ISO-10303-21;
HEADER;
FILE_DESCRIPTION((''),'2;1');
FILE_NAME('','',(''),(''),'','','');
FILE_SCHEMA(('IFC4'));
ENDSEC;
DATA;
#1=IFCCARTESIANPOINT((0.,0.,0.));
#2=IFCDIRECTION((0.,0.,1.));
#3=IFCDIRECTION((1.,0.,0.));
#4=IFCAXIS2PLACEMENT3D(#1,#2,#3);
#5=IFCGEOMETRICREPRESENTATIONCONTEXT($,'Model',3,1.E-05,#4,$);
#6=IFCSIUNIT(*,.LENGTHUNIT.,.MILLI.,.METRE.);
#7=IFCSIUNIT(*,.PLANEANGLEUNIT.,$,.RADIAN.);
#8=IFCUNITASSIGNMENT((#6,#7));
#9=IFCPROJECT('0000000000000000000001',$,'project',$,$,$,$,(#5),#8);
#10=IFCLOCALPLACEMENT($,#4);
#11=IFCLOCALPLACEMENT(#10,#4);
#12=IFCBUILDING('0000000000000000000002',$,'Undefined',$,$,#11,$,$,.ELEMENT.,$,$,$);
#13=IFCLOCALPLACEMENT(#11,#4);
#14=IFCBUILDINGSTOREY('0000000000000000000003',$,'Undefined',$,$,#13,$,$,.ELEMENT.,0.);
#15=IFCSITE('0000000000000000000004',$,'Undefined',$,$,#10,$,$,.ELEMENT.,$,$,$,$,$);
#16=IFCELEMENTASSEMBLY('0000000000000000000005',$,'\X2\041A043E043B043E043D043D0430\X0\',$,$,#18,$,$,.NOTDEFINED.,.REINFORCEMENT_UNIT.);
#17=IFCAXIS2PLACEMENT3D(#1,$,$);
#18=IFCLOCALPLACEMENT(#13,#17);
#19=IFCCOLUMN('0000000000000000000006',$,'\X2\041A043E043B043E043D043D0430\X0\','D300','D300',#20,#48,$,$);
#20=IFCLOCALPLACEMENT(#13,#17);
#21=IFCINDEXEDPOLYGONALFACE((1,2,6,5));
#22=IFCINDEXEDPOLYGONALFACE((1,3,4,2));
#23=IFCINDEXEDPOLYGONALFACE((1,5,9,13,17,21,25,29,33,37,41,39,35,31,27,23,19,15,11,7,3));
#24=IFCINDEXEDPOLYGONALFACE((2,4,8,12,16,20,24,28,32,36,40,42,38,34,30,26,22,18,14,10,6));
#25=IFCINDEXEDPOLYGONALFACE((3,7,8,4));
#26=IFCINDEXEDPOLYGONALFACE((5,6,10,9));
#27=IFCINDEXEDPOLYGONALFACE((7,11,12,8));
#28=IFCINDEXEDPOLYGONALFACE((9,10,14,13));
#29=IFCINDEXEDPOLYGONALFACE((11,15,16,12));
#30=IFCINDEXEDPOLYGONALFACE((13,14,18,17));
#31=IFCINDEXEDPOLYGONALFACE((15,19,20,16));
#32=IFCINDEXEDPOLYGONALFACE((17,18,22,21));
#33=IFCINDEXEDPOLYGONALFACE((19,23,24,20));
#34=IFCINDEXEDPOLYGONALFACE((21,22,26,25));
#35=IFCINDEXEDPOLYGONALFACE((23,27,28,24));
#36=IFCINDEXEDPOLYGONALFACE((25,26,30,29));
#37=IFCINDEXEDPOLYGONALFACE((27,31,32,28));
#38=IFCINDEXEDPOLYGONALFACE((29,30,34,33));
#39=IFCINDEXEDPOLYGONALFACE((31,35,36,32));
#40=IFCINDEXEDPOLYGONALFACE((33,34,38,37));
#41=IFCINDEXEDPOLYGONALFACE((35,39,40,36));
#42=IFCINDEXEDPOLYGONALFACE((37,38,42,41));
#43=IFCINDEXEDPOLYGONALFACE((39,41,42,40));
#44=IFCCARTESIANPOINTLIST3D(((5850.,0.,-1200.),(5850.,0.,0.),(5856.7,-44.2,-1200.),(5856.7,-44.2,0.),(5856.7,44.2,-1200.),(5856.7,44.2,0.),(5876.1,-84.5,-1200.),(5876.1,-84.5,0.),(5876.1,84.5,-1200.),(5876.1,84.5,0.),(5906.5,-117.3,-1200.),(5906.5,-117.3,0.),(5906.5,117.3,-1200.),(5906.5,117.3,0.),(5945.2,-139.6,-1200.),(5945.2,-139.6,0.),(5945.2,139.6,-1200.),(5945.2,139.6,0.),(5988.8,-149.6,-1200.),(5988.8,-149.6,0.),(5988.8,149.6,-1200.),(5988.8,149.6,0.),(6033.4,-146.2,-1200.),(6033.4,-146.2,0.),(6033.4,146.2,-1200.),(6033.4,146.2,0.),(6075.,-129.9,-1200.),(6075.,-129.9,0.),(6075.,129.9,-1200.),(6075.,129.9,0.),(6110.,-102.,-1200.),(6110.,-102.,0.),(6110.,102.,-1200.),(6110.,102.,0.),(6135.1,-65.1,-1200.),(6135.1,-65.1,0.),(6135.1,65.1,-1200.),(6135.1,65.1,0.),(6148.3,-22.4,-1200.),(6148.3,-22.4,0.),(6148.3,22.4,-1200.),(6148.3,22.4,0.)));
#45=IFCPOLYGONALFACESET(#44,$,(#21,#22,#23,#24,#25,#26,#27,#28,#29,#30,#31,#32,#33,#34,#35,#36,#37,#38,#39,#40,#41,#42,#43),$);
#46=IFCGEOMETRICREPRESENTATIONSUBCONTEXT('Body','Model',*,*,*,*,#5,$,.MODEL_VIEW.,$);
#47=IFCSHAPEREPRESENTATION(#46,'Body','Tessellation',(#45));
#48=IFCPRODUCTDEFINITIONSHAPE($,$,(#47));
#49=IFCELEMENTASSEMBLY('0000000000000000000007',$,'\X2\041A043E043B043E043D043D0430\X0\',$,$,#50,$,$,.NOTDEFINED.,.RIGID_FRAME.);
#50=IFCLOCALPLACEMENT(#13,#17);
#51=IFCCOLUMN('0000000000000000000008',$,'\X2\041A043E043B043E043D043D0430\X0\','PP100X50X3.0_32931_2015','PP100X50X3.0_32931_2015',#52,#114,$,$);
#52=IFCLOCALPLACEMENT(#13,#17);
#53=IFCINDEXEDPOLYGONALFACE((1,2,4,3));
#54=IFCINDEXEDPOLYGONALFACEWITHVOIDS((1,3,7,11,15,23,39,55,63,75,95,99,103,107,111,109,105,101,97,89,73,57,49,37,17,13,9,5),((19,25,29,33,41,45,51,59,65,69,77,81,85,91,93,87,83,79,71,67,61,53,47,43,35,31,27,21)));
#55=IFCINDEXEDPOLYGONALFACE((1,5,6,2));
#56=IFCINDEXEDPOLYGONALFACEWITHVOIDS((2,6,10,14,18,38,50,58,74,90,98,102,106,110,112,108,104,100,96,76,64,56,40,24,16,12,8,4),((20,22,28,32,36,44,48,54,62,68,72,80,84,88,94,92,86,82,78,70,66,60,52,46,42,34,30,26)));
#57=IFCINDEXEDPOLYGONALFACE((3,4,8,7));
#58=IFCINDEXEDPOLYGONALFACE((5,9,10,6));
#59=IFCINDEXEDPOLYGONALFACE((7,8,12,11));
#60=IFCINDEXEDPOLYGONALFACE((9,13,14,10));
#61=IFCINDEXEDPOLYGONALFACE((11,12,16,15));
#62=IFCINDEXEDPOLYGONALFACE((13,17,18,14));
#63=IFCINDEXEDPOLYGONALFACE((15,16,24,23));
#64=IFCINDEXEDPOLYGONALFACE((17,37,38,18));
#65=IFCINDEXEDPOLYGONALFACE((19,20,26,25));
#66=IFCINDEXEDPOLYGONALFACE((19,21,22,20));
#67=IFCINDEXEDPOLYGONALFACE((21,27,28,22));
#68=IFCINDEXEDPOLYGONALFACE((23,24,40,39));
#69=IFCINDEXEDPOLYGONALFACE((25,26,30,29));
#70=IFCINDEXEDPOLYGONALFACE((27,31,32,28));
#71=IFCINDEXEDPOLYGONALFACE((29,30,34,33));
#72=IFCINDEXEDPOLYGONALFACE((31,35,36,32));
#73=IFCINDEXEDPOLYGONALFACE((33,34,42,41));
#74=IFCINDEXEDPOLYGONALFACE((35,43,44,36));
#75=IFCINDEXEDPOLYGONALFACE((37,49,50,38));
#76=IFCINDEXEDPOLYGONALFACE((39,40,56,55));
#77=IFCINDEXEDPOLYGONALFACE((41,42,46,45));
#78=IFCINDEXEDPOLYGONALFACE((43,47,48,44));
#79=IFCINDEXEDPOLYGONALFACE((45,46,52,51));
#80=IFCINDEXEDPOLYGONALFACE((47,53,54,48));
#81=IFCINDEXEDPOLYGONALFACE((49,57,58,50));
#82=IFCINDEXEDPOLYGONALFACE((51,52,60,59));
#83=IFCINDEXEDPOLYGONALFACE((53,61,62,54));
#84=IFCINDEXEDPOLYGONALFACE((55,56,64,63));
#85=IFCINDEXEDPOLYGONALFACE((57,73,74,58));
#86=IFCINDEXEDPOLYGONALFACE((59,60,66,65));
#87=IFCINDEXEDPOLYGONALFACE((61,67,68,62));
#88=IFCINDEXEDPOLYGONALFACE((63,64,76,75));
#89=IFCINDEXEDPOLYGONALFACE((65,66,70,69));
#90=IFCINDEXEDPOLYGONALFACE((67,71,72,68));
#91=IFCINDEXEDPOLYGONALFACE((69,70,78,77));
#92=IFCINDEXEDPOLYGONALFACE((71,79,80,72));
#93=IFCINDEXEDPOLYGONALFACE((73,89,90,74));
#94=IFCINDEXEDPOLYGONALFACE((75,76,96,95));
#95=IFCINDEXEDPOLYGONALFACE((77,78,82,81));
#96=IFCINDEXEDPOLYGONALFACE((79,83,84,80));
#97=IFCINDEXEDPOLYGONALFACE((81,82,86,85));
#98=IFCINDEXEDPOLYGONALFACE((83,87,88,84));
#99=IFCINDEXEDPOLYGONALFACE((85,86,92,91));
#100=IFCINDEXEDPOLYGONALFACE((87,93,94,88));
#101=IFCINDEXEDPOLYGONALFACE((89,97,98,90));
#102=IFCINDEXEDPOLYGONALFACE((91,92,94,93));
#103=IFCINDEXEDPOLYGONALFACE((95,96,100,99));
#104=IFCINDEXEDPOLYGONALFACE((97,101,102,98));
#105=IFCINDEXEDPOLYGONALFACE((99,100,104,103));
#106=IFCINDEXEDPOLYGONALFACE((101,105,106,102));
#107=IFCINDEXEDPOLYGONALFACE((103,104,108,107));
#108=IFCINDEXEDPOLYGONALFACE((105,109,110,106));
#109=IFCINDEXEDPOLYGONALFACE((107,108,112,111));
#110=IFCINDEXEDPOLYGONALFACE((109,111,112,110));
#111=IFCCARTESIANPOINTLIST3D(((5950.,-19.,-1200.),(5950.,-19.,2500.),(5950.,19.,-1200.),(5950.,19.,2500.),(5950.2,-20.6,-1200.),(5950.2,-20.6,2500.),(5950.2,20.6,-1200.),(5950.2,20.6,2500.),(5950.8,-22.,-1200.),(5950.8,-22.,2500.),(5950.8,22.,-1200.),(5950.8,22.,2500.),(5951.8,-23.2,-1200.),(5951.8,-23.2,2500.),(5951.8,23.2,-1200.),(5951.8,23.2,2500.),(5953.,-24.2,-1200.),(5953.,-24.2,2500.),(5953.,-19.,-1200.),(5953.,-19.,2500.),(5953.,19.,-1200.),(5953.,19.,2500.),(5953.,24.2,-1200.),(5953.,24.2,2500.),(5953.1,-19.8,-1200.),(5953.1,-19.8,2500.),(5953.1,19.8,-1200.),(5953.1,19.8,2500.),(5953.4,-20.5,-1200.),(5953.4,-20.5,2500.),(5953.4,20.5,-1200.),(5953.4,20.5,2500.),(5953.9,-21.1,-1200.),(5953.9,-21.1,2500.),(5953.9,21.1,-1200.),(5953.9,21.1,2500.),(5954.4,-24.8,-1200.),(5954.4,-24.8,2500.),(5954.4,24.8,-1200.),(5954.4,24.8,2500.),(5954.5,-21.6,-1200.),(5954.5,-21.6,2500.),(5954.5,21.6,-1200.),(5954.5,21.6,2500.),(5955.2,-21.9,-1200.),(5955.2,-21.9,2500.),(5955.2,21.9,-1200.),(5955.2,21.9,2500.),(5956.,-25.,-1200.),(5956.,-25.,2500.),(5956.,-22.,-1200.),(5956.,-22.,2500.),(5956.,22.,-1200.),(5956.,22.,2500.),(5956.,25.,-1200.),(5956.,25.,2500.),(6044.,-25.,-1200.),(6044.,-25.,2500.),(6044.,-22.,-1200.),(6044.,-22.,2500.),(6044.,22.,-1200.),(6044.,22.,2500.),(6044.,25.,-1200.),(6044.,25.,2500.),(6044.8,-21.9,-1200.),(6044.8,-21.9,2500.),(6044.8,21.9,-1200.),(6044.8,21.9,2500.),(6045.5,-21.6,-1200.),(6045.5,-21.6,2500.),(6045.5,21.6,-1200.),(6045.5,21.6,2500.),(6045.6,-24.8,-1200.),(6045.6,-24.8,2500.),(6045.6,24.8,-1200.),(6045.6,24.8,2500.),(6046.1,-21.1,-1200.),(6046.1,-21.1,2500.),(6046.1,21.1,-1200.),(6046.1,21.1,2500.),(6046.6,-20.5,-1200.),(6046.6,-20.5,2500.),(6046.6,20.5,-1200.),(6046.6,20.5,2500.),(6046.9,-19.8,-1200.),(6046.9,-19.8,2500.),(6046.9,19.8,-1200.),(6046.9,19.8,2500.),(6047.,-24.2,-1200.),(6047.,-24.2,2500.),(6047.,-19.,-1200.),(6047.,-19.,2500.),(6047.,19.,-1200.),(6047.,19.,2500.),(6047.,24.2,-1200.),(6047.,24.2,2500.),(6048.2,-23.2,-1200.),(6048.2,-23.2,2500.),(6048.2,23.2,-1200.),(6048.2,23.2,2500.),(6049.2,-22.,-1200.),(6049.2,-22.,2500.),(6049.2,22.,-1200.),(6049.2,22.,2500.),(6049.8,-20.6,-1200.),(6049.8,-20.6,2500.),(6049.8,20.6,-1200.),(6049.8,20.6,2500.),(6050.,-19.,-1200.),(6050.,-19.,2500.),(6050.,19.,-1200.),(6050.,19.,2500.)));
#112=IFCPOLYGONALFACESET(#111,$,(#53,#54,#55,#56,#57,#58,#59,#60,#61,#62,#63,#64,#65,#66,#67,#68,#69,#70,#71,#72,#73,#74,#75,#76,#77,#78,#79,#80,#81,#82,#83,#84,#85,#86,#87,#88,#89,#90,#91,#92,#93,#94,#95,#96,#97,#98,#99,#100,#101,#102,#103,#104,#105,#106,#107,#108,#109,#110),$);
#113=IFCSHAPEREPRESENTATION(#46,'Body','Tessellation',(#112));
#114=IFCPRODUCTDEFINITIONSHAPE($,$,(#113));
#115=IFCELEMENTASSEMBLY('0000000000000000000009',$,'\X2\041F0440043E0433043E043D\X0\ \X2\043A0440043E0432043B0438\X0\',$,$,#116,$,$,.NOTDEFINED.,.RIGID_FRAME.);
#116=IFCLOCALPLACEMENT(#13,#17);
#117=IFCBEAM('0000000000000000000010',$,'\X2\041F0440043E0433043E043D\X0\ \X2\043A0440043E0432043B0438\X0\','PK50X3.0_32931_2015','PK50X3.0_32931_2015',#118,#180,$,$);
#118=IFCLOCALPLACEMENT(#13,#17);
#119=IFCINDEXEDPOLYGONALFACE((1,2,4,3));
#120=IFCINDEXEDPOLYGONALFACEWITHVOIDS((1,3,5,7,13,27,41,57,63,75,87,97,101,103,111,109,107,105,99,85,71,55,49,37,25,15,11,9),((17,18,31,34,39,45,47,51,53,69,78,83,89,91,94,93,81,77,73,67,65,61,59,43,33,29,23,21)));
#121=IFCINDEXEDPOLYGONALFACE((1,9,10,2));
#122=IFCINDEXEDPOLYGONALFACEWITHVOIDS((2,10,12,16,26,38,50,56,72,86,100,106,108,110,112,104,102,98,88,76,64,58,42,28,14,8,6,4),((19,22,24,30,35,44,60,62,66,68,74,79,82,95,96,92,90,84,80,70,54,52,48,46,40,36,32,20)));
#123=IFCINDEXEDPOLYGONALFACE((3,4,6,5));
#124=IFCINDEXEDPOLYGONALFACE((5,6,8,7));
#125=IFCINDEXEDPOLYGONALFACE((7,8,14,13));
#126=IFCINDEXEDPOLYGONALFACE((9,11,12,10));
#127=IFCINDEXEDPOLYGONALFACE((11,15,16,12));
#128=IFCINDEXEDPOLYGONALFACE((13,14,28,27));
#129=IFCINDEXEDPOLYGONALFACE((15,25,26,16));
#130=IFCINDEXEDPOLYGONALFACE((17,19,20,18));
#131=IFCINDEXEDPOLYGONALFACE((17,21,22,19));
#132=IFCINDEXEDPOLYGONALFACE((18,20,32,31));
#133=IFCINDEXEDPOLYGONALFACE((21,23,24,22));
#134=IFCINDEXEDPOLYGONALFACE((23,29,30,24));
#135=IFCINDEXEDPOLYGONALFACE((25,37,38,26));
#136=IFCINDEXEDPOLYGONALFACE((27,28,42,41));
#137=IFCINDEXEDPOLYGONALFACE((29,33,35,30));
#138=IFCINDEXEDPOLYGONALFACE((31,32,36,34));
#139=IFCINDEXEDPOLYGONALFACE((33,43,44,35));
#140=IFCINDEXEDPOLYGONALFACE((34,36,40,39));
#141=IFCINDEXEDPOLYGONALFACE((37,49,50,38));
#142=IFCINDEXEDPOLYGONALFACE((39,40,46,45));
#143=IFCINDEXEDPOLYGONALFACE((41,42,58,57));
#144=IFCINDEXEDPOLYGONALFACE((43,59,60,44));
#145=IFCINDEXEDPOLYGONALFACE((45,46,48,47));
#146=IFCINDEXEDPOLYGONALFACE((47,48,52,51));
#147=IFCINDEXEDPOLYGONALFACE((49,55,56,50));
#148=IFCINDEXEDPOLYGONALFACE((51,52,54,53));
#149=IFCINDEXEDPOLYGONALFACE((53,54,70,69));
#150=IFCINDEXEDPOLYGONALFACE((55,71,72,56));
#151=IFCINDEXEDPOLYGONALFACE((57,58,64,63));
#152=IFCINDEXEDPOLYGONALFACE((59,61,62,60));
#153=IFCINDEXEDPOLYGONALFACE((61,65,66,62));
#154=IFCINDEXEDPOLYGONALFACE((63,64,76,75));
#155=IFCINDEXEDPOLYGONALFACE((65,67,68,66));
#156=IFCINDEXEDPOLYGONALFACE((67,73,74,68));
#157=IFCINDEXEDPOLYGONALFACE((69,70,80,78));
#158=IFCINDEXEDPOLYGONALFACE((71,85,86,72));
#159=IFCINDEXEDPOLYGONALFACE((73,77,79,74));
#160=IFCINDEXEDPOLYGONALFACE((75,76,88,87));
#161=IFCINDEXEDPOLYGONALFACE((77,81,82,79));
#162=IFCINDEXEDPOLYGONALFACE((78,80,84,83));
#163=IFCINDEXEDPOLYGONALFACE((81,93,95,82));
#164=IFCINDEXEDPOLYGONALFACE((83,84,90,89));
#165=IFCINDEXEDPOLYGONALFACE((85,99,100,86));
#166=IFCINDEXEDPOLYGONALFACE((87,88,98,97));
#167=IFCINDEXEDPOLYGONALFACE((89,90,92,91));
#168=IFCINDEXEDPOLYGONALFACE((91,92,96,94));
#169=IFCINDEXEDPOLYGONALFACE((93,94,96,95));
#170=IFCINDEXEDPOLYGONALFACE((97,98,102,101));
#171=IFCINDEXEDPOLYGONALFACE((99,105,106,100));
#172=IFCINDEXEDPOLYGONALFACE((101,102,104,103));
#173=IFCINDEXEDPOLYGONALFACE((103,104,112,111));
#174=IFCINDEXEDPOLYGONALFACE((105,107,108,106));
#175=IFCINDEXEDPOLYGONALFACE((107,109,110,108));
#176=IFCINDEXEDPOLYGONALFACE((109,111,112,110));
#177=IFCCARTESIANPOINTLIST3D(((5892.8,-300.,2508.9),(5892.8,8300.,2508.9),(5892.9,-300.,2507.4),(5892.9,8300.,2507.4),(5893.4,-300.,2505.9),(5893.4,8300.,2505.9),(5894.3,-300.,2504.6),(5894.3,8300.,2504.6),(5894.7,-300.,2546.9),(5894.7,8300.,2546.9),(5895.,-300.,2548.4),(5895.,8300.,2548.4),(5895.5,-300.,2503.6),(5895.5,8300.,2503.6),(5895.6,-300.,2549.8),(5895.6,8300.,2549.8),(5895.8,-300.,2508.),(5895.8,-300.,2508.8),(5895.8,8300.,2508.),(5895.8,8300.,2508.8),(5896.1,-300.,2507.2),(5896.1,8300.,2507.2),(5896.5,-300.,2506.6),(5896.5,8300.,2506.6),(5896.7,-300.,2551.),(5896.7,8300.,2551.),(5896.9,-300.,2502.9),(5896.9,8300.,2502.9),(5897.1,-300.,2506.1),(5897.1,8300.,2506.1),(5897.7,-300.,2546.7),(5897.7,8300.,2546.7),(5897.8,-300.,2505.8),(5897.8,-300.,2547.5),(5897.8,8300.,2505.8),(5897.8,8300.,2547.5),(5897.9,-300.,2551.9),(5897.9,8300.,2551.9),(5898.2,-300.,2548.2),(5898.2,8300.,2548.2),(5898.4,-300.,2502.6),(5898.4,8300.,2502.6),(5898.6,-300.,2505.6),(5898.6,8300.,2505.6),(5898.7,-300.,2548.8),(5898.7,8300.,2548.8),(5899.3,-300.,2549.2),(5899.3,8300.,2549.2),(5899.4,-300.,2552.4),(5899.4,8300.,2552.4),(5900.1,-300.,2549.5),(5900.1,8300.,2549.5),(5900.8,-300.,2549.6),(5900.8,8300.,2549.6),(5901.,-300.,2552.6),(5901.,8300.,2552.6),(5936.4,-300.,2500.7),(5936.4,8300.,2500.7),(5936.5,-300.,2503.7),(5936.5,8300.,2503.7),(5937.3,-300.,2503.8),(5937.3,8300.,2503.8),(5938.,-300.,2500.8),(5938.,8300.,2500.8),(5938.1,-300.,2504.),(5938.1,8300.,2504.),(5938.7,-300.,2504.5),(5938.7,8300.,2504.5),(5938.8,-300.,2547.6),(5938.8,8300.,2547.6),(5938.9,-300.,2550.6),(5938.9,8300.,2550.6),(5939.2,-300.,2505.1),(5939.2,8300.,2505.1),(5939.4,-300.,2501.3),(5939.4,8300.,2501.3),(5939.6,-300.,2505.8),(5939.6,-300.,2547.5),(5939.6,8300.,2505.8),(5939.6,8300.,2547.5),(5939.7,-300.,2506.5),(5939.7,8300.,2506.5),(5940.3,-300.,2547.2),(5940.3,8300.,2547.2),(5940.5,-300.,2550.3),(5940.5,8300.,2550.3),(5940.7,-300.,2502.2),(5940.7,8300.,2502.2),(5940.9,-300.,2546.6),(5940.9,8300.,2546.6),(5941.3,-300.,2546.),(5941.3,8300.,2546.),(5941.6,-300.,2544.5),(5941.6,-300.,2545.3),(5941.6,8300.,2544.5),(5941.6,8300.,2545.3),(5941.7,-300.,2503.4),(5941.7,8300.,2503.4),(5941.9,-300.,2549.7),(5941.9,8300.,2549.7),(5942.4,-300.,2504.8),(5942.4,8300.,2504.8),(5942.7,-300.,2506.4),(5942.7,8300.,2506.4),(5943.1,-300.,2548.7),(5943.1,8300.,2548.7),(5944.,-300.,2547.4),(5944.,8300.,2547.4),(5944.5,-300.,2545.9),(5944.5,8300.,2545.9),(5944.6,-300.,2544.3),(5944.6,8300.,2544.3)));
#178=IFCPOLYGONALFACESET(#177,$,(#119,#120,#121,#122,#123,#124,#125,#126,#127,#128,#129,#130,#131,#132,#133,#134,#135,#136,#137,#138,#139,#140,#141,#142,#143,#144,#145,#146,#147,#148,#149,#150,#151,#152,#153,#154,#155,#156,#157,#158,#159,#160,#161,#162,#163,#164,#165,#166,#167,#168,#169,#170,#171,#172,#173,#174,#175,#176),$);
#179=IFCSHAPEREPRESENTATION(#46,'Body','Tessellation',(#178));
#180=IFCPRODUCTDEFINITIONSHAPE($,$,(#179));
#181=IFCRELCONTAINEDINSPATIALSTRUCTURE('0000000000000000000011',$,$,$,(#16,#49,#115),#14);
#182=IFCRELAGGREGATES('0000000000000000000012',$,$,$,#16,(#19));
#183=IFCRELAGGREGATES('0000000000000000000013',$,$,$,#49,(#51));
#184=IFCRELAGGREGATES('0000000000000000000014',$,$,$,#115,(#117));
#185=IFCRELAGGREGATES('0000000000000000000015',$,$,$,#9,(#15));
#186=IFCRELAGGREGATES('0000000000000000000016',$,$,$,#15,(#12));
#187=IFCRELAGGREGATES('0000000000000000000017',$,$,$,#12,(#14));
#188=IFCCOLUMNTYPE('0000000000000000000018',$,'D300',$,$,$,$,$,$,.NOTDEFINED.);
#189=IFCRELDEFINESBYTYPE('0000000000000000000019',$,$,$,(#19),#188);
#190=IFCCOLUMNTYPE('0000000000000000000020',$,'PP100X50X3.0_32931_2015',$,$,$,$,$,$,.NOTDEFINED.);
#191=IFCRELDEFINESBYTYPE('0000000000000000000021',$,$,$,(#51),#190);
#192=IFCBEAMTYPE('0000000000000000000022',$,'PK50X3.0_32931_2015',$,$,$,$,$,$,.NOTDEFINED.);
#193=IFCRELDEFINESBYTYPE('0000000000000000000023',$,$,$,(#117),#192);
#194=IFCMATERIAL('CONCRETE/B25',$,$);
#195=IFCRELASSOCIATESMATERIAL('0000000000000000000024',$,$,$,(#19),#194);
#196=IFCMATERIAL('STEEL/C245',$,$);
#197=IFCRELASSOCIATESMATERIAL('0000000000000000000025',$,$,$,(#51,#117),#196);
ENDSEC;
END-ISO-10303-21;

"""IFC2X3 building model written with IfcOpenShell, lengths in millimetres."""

from ifc_helpers import new_model, si_unit, frame, origin_with_axes, origin_2d_with_axis, place, context, subcontext, project, spatial, hollow_rectangle, circle, extrude, material, type_object, element, aggregate, save


model = new_model("IFC2X3")

# Units and contexts
model_context = context("Model", 3, precision=1e-05, world=origin_with_axes())
body_context = subcontext(model_context, "Body", "Model", "MODEL_VIEW")
ifc_project = project(units=[si_unit("LENGTHUNIT", "METRE", prefix="MILLI"), si_unit("PLANEANGLEUNIT", "RADIAN")], contexts=[model_context])

# Site, building, storey
site_placement = place(None, origin_with_axes())
site = spatial("IfcSite", under=ifc_project, at=site_placement, Name="Undefined", CompositionType="ELEMENT")
building_placement = place(site_placement, origin_with_axes())
building = spatial("IfcBuilding", under=site, at=building_placement, Name="Undefined", CompositionType="ELEMENT")
storey_placement = place(building_placement, origin_with_axes())
storey = spatial("IfcBuildingStorey", under=building, at=storey_placement, Name="Undefined", CompositionType="ELEMENT", Elevation=0.0)

# Element assemblies, columns
assembly_1_placement = place(storey_placement, origin_with_axes())
assembly_1 = element("IfcElementAssembly", 1, at=assembly_1_placement, inside=storey, Name="Колонна", AssemblyPlace="NOTDEFINED", PredefinedType="REINFORCEMENT_UNIT")
ifc_material_1 = material(Name="CONCRETE/B25")
column_type_1 = type_object("IfcColumnType", Name="D300", PredefinedType="NOTDEFINED")
column_1_placement = place(assembly_1_placement, frame((6000.0, 0.0, -1200.0), z_axis=(0.0, 0.0, 1.0), x_axis=(0.0, 1.0, 0.0)))
column_1 = element("IfcColumn", 2, at=column_1_placement, type_object=column_type_1, material=ifc_material_1, Name="Колонна", Description="D300", ObjectType="D300", context=body_context, shape_type="SweptSolid", body=[
    extrude(circle(Radius=150.0, at=origin_2d_with_axis()), frame((0.0, 0.0, 1200.0), z_axis=(0.0, 0.0, -1.0), x_axis=(0.0, 1.0, 0.0)), (0.0, 0.0, 1.0), 1200.0),
])
aggregate(assembly_1, [column_1])
assembly_2_placement = place(storey_placement, origin_with_axes())
assembly_2 = element("IfcElementAssembly", 3, at=assembly_2_placement, inside=storey, Name="Колонна", AssemblyPlace="NOTDEFINED", PredefinedType="RIGID_FRAME")
ifc_material_2 = material(Name="STEEL/C245")
column_type_2 = type_object("IfcColumnType", Name="PP100X50X3.0_32931_2015", PredefinedType="NOTDEFINED")
column_2_placement = place(assembly_2_placement, frame((6000.0, 0.0, -1200.0), z_axis=(0.0, 0.0, 1.0), x_axis=(-1.0, 0.0, 0.0)))
column_2 = element("IfcColumn", 4, at=column_2_placement, type_object=column_type_2, material=ifc_material_2, Name="Колонна", Description="PP100X50X3.0_32931_2015", ObjectType="PP100X50X3.0_32931_2015", context=body_context, shape_type="SweptSolid", body=[
    extrude(hollow_rectangle(XDim=50.0, YDim=100.0, WallThickness=3.0, InnerFilletRadius=3.0, OuterFilletRadius=6.0, at=origin_2d_with_axis()), frame((0.0, 0.0, 3700.0), z_axis=(0.0, 0.0, -1.0), x_axis=(0.0, 1.0, 0.0)), (0.0, 0.0, 1.0), 3700.0),
])
aggregate(assembly_2, [column_2])

# Element assembly, beam
assembly_3_placement = place(storey_placement, origin_with_axes())
assembly_3 = element("IfcElementAssembly", 5, at=assembly_3_placement, inside=storey, Name="Прогон кровли", AssemblyPlace="NOTDEFINED", PredefinedType="RIGID_FRAME")
beam_type_1 = type_object("IfcBeamType", Name="PK50X3.0_32931_2015", PredefinedType="NOTDEFINED")
beam_1_placement = place(assembly_3_placement, frame((5918.7, -300.0, 2526.6), z_axis=(0.050782, 0.0, 0.99871), x_axis=(0.0, 1.0, 0.0)))
beam_1 = element("IfcBeam", 6, at=beam_1_placement, type_object=beam_type_1, material=ifc_material_2, Name="Прогон кровли", Description="PK50X3.0_32931_2015", ObjectType="PK50X3.0_32931_2015", context=body_context, shape_type="SweptSolid", body=[
    extrude(hollow_rectangle(XDim=50.0, YDim=50.0, WallThickness=3.0, InnerFilletRadius=3.0, OuterFilletRadius=6.0, at=origin_2d_with_axis()), frame((8600.0, 0.0, 0.0), z_axis=(-1.0, 0.0, 0.0), x_axis=(0.0, -1.0, 0.0)), (0.0, 0.0, 1.0), 8600.0),
])
aggregate(assembly_3, [beam_1])

save(model, "model.ifc")
